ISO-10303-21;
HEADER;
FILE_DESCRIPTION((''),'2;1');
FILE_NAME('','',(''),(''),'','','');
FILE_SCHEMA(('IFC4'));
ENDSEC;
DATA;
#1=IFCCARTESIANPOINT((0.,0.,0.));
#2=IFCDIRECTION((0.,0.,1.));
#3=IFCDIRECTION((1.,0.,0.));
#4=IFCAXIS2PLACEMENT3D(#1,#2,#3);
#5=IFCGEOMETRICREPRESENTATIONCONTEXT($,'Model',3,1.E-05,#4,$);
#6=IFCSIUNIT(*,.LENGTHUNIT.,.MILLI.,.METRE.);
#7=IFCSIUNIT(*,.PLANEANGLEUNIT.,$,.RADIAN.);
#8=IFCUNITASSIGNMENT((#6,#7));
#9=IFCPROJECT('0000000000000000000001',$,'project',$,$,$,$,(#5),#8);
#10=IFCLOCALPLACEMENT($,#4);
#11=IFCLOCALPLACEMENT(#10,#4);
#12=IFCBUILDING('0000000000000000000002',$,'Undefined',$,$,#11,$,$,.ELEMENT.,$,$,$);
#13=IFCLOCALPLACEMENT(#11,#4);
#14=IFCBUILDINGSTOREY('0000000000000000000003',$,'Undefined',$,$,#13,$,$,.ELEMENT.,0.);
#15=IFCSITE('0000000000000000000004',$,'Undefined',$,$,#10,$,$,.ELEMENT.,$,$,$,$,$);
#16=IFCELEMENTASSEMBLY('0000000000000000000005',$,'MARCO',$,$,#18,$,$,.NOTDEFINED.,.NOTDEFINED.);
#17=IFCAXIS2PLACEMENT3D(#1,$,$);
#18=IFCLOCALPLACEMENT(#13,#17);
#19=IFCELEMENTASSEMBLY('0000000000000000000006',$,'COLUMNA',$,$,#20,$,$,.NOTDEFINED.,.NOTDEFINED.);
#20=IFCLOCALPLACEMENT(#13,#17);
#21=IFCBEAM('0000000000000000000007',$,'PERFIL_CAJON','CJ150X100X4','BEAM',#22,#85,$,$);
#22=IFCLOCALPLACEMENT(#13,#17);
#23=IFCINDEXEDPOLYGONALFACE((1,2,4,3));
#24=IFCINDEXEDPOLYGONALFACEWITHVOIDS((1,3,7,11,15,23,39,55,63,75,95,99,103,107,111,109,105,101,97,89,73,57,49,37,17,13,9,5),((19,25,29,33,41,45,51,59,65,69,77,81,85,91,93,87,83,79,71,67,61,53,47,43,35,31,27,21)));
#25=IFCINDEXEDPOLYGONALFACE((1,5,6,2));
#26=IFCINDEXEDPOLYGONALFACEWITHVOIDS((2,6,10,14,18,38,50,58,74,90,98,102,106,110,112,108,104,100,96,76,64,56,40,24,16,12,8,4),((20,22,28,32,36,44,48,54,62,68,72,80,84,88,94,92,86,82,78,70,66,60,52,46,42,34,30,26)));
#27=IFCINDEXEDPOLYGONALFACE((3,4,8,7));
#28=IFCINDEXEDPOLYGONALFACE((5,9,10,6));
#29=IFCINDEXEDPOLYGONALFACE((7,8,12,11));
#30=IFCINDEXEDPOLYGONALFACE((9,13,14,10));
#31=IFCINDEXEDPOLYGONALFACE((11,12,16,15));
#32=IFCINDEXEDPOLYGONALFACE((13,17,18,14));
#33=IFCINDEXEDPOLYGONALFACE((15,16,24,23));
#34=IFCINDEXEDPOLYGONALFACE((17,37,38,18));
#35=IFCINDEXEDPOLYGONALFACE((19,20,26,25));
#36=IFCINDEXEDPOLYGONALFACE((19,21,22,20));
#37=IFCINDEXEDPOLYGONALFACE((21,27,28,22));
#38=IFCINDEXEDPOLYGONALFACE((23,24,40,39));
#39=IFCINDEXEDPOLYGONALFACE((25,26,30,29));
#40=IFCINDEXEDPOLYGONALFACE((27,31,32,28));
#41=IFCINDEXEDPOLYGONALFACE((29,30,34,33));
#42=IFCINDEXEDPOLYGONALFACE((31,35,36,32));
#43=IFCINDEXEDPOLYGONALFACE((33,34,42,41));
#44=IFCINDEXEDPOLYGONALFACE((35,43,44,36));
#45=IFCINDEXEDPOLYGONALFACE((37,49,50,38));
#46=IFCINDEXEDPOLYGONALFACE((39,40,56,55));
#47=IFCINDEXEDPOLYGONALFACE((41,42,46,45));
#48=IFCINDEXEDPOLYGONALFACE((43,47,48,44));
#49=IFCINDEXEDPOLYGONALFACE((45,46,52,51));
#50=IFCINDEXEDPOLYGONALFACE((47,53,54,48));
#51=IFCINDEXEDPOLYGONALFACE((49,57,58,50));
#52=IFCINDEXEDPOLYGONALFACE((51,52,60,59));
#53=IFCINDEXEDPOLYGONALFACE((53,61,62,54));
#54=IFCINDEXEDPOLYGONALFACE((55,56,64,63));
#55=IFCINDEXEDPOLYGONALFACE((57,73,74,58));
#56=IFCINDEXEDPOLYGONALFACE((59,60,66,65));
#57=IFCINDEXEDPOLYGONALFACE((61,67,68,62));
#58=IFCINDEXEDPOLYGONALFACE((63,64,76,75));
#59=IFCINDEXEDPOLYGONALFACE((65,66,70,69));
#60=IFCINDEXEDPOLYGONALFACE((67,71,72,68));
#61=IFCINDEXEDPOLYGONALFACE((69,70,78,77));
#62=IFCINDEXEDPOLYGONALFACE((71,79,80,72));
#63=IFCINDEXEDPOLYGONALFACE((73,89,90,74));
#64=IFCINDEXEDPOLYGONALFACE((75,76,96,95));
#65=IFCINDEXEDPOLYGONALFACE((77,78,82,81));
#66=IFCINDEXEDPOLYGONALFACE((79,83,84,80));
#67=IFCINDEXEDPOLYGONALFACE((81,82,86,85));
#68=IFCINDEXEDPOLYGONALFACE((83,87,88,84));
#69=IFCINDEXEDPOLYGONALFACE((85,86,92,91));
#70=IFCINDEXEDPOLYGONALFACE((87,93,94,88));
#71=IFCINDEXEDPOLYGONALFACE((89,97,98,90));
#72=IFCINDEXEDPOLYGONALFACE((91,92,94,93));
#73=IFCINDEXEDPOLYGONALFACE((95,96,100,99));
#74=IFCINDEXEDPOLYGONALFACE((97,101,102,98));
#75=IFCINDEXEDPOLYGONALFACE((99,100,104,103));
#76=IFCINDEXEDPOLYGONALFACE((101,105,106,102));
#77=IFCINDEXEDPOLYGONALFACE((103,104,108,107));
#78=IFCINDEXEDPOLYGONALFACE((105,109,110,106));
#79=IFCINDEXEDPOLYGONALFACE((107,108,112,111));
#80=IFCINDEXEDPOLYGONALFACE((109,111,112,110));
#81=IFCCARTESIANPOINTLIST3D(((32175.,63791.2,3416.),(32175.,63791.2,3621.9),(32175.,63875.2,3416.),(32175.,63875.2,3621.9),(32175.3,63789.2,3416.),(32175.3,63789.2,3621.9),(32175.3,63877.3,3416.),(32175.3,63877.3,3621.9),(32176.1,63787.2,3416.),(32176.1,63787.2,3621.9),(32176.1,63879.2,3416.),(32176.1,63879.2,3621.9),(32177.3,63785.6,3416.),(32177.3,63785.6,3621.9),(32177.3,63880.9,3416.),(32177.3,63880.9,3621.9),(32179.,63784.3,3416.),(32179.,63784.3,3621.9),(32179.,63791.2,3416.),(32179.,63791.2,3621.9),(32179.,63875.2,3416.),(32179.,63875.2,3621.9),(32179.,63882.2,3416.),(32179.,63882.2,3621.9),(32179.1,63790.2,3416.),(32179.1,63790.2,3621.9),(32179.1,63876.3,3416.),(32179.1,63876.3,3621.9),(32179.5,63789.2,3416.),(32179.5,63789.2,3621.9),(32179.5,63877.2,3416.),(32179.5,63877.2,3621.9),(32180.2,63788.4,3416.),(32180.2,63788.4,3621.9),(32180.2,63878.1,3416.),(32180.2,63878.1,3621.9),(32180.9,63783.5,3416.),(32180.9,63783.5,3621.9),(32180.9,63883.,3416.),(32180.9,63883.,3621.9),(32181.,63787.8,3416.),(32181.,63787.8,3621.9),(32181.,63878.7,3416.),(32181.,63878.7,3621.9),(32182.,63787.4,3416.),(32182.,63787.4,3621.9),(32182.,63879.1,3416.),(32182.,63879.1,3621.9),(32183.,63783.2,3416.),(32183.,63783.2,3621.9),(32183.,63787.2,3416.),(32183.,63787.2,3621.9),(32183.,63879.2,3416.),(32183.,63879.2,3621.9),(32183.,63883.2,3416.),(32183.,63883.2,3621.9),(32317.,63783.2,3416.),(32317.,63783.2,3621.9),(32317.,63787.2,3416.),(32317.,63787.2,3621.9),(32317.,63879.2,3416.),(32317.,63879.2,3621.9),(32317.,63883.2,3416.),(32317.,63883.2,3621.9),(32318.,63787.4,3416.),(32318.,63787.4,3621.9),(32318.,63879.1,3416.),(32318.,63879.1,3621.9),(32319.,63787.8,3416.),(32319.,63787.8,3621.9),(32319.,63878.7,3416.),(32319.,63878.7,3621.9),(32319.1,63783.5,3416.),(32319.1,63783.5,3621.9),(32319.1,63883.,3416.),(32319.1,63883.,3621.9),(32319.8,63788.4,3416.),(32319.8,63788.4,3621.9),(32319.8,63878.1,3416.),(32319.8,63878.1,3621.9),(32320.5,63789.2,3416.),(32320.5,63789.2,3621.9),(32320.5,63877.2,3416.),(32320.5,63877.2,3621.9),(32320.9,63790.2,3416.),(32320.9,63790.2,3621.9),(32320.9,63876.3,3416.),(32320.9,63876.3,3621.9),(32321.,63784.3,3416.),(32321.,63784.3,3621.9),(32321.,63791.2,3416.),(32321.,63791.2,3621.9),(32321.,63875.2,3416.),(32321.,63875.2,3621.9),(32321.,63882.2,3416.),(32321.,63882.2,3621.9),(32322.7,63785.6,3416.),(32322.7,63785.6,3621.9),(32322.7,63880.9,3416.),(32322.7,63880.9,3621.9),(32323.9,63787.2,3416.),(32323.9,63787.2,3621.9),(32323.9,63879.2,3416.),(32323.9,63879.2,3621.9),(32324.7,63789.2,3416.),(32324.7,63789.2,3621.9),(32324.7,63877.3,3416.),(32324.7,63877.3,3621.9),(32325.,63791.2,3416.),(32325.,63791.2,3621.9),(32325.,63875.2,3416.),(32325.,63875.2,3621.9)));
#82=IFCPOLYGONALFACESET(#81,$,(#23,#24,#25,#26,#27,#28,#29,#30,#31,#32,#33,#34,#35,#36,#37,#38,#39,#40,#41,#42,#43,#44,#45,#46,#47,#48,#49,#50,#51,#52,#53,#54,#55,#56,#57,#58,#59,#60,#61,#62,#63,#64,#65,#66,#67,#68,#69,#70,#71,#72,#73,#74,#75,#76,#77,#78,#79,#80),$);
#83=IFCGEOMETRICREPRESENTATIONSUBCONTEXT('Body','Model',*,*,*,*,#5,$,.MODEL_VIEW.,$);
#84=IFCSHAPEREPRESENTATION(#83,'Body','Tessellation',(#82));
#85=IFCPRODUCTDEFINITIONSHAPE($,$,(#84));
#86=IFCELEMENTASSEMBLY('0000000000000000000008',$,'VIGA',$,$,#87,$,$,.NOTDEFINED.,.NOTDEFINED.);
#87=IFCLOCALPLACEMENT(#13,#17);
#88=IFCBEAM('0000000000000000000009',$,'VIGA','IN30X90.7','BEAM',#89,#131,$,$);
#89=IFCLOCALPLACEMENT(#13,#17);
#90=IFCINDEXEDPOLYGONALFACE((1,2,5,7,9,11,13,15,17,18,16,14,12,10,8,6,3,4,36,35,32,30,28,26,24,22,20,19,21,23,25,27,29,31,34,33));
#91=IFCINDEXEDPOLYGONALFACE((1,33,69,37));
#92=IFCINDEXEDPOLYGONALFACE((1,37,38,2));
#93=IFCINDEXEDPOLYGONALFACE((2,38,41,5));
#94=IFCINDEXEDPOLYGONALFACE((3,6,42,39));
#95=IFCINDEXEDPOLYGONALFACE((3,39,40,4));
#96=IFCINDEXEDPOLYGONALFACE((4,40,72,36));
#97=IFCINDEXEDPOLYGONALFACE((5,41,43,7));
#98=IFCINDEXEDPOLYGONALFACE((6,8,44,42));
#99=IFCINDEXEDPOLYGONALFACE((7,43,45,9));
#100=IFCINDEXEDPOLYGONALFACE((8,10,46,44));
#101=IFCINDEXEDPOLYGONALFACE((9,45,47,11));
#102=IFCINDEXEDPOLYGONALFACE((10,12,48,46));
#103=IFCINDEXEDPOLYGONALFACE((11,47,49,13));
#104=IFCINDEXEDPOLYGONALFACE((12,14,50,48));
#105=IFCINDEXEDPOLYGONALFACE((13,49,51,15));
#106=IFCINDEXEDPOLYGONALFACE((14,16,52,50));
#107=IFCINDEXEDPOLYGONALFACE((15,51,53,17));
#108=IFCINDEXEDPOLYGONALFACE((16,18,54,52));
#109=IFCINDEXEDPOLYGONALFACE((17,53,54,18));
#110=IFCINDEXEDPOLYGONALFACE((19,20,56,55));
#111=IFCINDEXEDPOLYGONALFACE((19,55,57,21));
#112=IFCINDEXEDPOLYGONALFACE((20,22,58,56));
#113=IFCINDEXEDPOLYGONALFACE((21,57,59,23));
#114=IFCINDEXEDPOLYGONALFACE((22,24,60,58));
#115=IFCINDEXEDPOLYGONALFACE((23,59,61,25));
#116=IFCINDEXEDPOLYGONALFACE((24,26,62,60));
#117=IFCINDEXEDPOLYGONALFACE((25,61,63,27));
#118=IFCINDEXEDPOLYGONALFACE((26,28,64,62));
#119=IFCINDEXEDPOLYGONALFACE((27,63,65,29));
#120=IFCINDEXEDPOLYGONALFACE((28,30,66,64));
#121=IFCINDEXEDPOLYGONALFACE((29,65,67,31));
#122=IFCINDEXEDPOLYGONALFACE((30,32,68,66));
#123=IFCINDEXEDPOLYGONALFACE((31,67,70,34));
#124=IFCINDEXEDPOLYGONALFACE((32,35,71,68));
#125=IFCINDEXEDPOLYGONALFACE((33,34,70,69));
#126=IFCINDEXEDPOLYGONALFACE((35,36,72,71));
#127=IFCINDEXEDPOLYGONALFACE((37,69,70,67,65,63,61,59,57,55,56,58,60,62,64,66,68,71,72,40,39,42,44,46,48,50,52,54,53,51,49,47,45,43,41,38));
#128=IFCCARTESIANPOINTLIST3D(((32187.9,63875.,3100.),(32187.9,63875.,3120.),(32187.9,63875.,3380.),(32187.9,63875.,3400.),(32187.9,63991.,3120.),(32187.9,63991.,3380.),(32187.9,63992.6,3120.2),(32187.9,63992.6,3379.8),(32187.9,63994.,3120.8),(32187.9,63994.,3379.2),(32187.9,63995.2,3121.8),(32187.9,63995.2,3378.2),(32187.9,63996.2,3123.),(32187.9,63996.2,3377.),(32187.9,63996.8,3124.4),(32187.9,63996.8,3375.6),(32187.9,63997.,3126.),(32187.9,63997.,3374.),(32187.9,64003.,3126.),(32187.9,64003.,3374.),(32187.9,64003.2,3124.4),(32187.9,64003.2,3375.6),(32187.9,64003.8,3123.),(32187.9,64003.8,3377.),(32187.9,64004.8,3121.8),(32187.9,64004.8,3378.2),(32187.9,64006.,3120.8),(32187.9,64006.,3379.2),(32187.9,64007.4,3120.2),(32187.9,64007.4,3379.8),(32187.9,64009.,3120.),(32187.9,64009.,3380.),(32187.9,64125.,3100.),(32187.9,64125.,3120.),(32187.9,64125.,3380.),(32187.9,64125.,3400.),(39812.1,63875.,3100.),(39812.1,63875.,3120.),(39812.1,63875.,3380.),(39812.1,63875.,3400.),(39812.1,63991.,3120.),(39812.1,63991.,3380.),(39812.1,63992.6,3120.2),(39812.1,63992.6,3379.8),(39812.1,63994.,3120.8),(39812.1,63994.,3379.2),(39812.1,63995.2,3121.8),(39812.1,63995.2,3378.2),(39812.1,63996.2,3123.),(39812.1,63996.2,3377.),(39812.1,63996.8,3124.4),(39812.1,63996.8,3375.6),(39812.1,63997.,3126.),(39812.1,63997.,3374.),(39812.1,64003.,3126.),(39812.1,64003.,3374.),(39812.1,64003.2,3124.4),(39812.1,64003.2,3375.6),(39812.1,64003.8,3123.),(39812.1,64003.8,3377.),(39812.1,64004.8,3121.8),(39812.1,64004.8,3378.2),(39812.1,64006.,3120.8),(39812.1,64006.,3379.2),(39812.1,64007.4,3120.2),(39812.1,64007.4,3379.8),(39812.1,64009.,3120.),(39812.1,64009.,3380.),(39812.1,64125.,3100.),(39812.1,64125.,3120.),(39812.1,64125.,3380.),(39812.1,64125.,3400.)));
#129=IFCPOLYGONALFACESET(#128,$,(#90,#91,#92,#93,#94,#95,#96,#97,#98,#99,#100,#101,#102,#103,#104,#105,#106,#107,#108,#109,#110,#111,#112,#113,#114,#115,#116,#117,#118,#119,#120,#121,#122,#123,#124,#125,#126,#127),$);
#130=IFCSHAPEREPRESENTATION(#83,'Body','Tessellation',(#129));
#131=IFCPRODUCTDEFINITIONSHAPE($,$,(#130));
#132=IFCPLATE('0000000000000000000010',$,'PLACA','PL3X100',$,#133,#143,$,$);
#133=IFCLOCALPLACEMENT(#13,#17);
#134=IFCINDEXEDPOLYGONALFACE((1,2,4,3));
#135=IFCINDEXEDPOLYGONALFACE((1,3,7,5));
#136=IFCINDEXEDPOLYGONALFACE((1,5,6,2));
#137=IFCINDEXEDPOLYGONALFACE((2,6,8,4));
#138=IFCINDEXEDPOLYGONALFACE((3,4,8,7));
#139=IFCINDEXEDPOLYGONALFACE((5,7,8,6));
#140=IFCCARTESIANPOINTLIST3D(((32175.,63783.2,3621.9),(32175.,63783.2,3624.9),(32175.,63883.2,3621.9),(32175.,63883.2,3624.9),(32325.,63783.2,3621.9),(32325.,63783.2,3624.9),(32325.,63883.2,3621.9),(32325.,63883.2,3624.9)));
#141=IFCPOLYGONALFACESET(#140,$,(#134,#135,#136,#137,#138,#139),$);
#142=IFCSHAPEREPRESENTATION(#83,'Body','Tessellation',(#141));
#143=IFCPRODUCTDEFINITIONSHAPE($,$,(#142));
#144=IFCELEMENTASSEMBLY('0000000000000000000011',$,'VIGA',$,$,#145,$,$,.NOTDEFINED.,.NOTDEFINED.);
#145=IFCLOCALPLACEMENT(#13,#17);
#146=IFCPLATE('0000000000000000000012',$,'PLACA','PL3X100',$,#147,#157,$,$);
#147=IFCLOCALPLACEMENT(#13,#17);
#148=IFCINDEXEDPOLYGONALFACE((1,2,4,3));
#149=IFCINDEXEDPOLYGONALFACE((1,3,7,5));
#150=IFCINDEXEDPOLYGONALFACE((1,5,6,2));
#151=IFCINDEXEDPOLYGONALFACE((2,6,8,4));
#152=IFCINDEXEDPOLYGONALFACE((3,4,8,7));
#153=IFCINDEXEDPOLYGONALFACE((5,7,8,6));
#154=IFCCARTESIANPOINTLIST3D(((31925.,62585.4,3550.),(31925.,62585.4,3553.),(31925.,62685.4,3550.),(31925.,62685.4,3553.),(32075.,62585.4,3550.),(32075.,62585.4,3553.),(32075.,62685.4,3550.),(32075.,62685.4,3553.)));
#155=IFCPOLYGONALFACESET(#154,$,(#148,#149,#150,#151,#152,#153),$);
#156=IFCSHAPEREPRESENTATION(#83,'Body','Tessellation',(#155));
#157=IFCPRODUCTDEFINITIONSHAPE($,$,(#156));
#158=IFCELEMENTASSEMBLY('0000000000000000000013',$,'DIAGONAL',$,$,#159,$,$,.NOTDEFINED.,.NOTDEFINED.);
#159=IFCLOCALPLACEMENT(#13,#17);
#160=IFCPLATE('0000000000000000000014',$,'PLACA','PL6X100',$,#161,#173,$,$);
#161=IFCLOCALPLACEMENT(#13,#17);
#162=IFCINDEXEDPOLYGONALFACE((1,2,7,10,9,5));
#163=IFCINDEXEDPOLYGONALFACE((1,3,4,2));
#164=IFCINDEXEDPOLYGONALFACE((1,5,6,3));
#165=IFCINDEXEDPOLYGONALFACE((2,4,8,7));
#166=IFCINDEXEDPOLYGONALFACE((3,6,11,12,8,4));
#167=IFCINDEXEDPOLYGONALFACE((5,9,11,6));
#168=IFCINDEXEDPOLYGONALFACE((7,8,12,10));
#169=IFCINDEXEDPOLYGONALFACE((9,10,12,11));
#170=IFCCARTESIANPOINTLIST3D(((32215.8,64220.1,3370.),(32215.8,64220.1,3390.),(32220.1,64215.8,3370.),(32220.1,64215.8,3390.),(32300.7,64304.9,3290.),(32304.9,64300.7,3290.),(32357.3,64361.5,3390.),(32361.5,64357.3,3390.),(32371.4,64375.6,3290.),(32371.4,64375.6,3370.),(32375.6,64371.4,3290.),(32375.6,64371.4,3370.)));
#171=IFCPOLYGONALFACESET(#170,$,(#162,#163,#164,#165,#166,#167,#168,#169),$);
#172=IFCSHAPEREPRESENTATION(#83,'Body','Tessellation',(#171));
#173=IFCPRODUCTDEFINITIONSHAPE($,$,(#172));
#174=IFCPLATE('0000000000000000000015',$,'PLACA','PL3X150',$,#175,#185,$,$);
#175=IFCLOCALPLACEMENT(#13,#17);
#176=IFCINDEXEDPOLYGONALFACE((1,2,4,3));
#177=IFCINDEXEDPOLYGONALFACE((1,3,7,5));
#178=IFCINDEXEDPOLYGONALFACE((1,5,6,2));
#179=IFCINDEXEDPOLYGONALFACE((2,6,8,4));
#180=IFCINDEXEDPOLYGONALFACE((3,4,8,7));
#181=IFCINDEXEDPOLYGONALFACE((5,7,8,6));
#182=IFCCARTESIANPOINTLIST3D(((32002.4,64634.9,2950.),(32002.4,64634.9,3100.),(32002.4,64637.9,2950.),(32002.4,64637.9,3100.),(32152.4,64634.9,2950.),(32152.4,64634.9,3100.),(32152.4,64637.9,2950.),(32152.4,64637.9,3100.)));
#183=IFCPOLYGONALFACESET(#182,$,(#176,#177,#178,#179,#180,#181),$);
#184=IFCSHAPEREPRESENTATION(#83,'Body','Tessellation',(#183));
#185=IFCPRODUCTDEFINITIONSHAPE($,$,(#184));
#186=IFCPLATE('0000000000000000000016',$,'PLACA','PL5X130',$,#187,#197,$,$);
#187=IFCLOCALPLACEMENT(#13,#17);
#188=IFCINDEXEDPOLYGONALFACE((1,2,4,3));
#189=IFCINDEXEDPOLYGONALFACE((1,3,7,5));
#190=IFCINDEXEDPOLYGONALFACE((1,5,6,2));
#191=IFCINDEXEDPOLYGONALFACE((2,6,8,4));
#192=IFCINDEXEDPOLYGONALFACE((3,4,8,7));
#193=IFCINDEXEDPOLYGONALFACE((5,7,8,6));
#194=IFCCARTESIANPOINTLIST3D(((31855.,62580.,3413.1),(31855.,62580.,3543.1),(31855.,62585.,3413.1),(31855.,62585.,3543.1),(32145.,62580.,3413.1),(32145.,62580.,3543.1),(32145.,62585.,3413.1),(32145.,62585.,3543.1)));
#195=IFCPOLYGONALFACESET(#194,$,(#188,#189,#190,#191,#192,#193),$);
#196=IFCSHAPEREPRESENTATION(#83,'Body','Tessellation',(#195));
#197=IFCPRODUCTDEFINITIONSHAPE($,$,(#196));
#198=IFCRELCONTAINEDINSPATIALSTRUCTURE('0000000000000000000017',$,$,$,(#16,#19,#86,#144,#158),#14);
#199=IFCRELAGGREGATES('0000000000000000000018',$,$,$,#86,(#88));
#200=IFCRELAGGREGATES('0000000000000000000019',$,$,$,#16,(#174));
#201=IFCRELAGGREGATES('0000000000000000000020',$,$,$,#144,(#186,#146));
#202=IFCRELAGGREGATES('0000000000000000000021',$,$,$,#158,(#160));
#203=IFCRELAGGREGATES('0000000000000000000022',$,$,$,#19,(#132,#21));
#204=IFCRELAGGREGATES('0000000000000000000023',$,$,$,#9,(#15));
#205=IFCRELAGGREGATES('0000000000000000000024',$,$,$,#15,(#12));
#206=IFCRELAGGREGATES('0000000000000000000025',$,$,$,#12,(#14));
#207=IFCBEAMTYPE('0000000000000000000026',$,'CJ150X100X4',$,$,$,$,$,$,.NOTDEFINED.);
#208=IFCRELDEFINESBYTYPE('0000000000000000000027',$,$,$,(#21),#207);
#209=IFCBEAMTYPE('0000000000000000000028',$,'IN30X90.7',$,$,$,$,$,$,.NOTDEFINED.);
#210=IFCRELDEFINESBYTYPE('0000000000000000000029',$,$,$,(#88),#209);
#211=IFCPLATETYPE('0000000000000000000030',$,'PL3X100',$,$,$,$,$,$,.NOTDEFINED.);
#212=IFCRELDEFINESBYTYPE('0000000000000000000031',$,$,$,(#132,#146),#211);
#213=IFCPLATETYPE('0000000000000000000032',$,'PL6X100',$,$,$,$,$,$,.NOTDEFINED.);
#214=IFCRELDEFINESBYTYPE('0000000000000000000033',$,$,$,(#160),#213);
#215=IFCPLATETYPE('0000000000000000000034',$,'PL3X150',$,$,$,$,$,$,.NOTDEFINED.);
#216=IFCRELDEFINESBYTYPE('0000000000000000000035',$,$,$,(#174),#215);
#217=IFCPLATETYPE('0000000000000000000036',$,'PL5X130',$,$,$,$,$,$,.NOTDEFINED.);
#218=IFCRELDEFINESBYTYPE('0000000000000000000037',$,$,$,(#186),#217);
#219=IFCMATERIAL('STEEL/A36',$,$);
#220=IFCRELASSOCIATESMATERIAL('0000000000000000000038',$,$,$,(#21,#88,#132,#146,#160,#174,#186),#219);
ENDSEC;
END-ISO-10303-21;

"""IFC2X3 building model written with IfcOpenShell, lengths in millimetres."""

from ifc_helpers import new_model, si_unit, frame, origin_with_axes, origin_2d_with_axis, place, context, subcontext, project, spatial, polyline, hollow_rectangle, i_section, outline, extrude, material, type_object, element, aggregate, save


model = new_model("IFC2X3")

# Units and contexts
model_context = context("Model", 3, precision=1e-05, world=origin_with_axes())
body_context = subcontext(model_context, "Body", "Model", "MODEL_VIEW")
ifc_project = project(units=[si_unit("LENGTHUNIT", "METRE", prefix="MILLI"), si_unit("PLANEANGLEUNIT", "RADIAN")], contexts=[model_context])

# Site, building, storey
site_placement = place(None, origin_with_axes())
site = spatial("IfcSite", under=ifc_project, at=site_placement, Name="Undefined", CompositionType="ELEMENT")
building_placement = place(site_placement, origin_with_axes())
building = spatial("IfcBuilding", under=site, at=building_placement, Name="Undefined", CompositionType="ELEMENT")
storey_placement = place(building_placement, origin_with_axes())
storey = spatial("IfcBuildingStorey", under=building, at=storey_placement, Name="Undefined", CompositionType="ELEMENT", Elevation=0.0)

# Element assembly
assembly_1_placement = place(storey_placement, origin_with_axes())
assembly_1 = element("IfcElementAssembly", 1, at=assembly_1_placement, inside=storey, Name="MARCO", AssemblyPlace="NOTDEFINED", PredefinedType="NOTDEFINED")
ifc_material_1 = material(Name="STEEL/A36")

# Element assemblies, beams
beam_type_1 = type_object("IfcBeamType", Name="CJ150X100X4", PredefinedType="NOTDEFINED")
assembly_2_placement = place(storey_placement, origin_with_axes())
assembly_2 = element("IfcElementAssembly", 2, at=assembly_2_placement, inside=storey, Name="COLUMNA", AssemblyPlace="NOTDEFINED", PredefinedType="NOTDEFINED")
beam_1_placement = place(assembly_2_placement, frame((32250.0, 63833.2, 3621.9), z_axis=(-1.0, 0.0, 0.0), x_axis=(0.0, 0.0, -1.0)))
beam_1 = element("IfcBeam", 3, at=beam_1_placement, type_object=beam_type_1, material=ifc_material_1, Name="PERFIL_CAJON", Description="CJ150X100X4", ObjectType="BEAM", context=body_context, shape_type="SweptSolid", body=[
    extrude(hollow_rectangle(XDim=100.0, YDim=150.0, WallThickness=4.0, InnerFilletRadius=4.0, OuterFilletRadius=8.0, at=origin_2d_with_axis()), frame((205.9, 0.0, 0.0), z_axis=(-1.0, 0.0, 0.0), x_axis=(0.0, -1.0, 0.0)), (0.0, 0.0, 1.0), 205.9),
])
assembly_3_placement = place(storey_placement, origin_with_axes())
assembly_3 = element("IfcElementAssembly", 4, at=assembly_3_placement, inside=storey, Name="VIGA", AssemblyPlace="NOTDEFINED", PredefinedType="NOTDEFINED")
beam_type_2 = type_object("IfcBeamType", Name="IN30X90.7", PredefinedType="NOTDEFINED")
beam_2_placement = place(assembly_3_placement, frame((32187.9, 64000.0, 3250.0), z_axis=(0.0, 0.0, 1.0), x_axis=(1.0, 0.0, 0.0)))
beam_2 = element("IfcBeam", 5, at=beam_2_placement, type_object=beam_type_2, material=ifc_material_1, Name="VIGA", Description="IN30X90.7", ObjectType="BEAM", context=body_context, shape_type="SweptSolid", body=[
    extrude(i_section(OverallWidth=250.0, OverallDepth=300.0, WebThickness=6.0, FlangeThickness=20.0, FilletRadius=6.0, at=origin_2d_with_axis()), frame((7624.2, 0.0, 0.0), z_axis=(-1.0, 0.0, 0.0), x_axis=(0.0, -1.0, 0.0)), (0.0, 0.0, 1.0), 7624.2),
])
aggregate(assembly_3, [beam_2])

# Plate
plate_type_1 = type_object("IfcPlateType", Name="PL3X100", PredefinedType="NOTDEFINED")
plate_1_placement = place(assembly_2_placement, frame((32325.0, 63883.2, 3623.4), z_axis=(0.0, 0.0, -1.0), x_axis=(0.0, -1.0, 0.0)))
plate_1 = element("IfcPlate", 6, at=plate_1_placement, type_object=plate_type_1, material=ifc_material_1, Name="PLACA", Description="PL3X100", context=body_context, shape_type="SweptSolid", body=[
    extrude(outline(polyline([(0.0, 0.0), (100.0, 0.0), (100.0, 150.0), (0.0, 150.0), (0.0, 0.0)])), frame((0.0, 0.0, -1.5), z_axis=(0.0, 0.0, 1.0), x_axis=(1.0, 0.0, 0.0)), (0.0, 0.0, 1.0), 3.0),
])

# Element assemblies, plates
assembly_4_placement = place(storey_placement, origin_with_axes())
assembly_4 = element("IfcElementAssembly", 7, at=assembly_4_placement, inside=storey, Name="VIGA", AssemblyPlace="NOTDEFINED", PredefinedType="NOTDEFINED")
plate_2_placement = place(assembly_4_placement, frame((32075.0, 62685.4, 3551.5), z_axis=(0.0, 0.0, -1.0), x_axis=(0.0, -1.0, 0.0)))
plate_2 = element("IfcPlate", 8, at=plate_2_placement, type_object=plate_type_1, material=ifc_material_1, Name="PLACA", Description="PL3X100", context=body_context, shape_type="SweptSolid", body=[
    extrude(outline(polyline([(0.0, 0.0), (100.0, 0.0), (100.0, 150.0), (0.0, 150.0), (0.0, 0.0)])), frame((0.0, 0.0, -1.5), z_axis=(0.0, 0.0, 1.0), x_axis=(1.0, 0.0, 0.0)), (0.0, 0.0, 1.0), 3.0),
])
assembly_5_placement = place(storey_placement, origin_with_axes())
assembly_5 = element("IfcElementAssembly", 9, at=assembly_5_placement, inside=storey, Name="DIAGONAL", AssemblyPlace="NOTDEFINED", PredefinedType="NOTDEFINED")
plate_type_2 = type_object("IfcPlateType", Name="PL6X100", PredefinedType="NOTDEFINED")
plate_3_placement = place(assembly_5_placement, frame((32218.0, 64218.0, 3290.0), z_axis=(0.707107, -0.707107, 0.0), x_axis=(0.707107, 0.707107, 0.0)))
plate_3 = element("IfcPlate", 10, at=plate_3_placement, type_object=plate_type_2, material=ifc_material_1, Name="PLACA", Description="PL6X100", context=body_context, shape_type="SweptSolid", body=[
    extrude(outline(polyline([(0.0, 80.0), (120.0, 0.0), (220.0, 0.0), (220.0, 80.0), (200.0, 100.0), (0.0, 100.0), (0.0, 80.0)])), frame((0.0, 0.0, -3.0), z_axis=(0.0, 0.0, 1.0), x_axis=(1.0, 0.0, 0.0)), (0.0, 0.0, 1.0), 6.0),
])

# Plates
plate_type_3 = type_object("IfcPlateType", Name="PL3X150", PredefinedType="NOTDEFINED")
plate_4_placement = place(assembly_1_placement, frame((32152.4, 64636.4, 2950.0), z_axis=(0.0, 1.0, 0.0), x_axis=(-1.0, 0.0, 0.0)))
plate_4 = element("IfcPlate", 11, at=plate_4_placement, type_object=plate_type_3, material=ifc_material_1, Name="PLACA", Description="PL3X150", context=body_context, shape_type="SweptSolid", body=[
    extrude(outline(polyline([(0.0, 0.0), (150.0, 0.0), (150.0, 150.0), (0.0, 150.0), (0.0, 0.0)])), frame((0.0, 0.0, -1.5), z_axis=(0.0, 0.0, 1.0), x_axis=(1.0, 0.0, 0.0)), (0.0, 0.0, 1.0), 3.0),
])
aggregate(assembly_1, [plate_4])
plate_type_4 = type_object("IfcPlateType", Name="PL5X130", PredefinedType="NOTDEFINED")
plate_5_placement = place(assembly_4_placement, frame((32145.0, 62582.5, 3543.1), z_axis=(0.0, -1.0, 0.0), x_axis=(-1.0, 0.0, 0.0)))
plate_5 = element("IfcPlate", 12, at=plate_5_placement, type_object=plate_type_4, material=ifc_material_1, Name="PLACA", Description="PL5X130", context=body_context, shape_type="SweptSolid", body=[
    extrude(outline(polyline([(0.0, 0.0), (290.0, 0.0), (290.0, 130.0), (0.0, 130.0), (0.0, 0.0)])), frame((0.0, 0.0, -2.5), z_axis=(0.0, 0.0, 1.0), x_axis=(1.0, 0.0, 0.0)), (0.0, 0.0, 1.0), 5.0),
])
aggregate(assembly_4, [plate_5, plate_2])

aggregate(assembly_5, [plate_3])
aggregate(assembly_2, [plate_1, beam_1])

save(model, "model.ifc")
